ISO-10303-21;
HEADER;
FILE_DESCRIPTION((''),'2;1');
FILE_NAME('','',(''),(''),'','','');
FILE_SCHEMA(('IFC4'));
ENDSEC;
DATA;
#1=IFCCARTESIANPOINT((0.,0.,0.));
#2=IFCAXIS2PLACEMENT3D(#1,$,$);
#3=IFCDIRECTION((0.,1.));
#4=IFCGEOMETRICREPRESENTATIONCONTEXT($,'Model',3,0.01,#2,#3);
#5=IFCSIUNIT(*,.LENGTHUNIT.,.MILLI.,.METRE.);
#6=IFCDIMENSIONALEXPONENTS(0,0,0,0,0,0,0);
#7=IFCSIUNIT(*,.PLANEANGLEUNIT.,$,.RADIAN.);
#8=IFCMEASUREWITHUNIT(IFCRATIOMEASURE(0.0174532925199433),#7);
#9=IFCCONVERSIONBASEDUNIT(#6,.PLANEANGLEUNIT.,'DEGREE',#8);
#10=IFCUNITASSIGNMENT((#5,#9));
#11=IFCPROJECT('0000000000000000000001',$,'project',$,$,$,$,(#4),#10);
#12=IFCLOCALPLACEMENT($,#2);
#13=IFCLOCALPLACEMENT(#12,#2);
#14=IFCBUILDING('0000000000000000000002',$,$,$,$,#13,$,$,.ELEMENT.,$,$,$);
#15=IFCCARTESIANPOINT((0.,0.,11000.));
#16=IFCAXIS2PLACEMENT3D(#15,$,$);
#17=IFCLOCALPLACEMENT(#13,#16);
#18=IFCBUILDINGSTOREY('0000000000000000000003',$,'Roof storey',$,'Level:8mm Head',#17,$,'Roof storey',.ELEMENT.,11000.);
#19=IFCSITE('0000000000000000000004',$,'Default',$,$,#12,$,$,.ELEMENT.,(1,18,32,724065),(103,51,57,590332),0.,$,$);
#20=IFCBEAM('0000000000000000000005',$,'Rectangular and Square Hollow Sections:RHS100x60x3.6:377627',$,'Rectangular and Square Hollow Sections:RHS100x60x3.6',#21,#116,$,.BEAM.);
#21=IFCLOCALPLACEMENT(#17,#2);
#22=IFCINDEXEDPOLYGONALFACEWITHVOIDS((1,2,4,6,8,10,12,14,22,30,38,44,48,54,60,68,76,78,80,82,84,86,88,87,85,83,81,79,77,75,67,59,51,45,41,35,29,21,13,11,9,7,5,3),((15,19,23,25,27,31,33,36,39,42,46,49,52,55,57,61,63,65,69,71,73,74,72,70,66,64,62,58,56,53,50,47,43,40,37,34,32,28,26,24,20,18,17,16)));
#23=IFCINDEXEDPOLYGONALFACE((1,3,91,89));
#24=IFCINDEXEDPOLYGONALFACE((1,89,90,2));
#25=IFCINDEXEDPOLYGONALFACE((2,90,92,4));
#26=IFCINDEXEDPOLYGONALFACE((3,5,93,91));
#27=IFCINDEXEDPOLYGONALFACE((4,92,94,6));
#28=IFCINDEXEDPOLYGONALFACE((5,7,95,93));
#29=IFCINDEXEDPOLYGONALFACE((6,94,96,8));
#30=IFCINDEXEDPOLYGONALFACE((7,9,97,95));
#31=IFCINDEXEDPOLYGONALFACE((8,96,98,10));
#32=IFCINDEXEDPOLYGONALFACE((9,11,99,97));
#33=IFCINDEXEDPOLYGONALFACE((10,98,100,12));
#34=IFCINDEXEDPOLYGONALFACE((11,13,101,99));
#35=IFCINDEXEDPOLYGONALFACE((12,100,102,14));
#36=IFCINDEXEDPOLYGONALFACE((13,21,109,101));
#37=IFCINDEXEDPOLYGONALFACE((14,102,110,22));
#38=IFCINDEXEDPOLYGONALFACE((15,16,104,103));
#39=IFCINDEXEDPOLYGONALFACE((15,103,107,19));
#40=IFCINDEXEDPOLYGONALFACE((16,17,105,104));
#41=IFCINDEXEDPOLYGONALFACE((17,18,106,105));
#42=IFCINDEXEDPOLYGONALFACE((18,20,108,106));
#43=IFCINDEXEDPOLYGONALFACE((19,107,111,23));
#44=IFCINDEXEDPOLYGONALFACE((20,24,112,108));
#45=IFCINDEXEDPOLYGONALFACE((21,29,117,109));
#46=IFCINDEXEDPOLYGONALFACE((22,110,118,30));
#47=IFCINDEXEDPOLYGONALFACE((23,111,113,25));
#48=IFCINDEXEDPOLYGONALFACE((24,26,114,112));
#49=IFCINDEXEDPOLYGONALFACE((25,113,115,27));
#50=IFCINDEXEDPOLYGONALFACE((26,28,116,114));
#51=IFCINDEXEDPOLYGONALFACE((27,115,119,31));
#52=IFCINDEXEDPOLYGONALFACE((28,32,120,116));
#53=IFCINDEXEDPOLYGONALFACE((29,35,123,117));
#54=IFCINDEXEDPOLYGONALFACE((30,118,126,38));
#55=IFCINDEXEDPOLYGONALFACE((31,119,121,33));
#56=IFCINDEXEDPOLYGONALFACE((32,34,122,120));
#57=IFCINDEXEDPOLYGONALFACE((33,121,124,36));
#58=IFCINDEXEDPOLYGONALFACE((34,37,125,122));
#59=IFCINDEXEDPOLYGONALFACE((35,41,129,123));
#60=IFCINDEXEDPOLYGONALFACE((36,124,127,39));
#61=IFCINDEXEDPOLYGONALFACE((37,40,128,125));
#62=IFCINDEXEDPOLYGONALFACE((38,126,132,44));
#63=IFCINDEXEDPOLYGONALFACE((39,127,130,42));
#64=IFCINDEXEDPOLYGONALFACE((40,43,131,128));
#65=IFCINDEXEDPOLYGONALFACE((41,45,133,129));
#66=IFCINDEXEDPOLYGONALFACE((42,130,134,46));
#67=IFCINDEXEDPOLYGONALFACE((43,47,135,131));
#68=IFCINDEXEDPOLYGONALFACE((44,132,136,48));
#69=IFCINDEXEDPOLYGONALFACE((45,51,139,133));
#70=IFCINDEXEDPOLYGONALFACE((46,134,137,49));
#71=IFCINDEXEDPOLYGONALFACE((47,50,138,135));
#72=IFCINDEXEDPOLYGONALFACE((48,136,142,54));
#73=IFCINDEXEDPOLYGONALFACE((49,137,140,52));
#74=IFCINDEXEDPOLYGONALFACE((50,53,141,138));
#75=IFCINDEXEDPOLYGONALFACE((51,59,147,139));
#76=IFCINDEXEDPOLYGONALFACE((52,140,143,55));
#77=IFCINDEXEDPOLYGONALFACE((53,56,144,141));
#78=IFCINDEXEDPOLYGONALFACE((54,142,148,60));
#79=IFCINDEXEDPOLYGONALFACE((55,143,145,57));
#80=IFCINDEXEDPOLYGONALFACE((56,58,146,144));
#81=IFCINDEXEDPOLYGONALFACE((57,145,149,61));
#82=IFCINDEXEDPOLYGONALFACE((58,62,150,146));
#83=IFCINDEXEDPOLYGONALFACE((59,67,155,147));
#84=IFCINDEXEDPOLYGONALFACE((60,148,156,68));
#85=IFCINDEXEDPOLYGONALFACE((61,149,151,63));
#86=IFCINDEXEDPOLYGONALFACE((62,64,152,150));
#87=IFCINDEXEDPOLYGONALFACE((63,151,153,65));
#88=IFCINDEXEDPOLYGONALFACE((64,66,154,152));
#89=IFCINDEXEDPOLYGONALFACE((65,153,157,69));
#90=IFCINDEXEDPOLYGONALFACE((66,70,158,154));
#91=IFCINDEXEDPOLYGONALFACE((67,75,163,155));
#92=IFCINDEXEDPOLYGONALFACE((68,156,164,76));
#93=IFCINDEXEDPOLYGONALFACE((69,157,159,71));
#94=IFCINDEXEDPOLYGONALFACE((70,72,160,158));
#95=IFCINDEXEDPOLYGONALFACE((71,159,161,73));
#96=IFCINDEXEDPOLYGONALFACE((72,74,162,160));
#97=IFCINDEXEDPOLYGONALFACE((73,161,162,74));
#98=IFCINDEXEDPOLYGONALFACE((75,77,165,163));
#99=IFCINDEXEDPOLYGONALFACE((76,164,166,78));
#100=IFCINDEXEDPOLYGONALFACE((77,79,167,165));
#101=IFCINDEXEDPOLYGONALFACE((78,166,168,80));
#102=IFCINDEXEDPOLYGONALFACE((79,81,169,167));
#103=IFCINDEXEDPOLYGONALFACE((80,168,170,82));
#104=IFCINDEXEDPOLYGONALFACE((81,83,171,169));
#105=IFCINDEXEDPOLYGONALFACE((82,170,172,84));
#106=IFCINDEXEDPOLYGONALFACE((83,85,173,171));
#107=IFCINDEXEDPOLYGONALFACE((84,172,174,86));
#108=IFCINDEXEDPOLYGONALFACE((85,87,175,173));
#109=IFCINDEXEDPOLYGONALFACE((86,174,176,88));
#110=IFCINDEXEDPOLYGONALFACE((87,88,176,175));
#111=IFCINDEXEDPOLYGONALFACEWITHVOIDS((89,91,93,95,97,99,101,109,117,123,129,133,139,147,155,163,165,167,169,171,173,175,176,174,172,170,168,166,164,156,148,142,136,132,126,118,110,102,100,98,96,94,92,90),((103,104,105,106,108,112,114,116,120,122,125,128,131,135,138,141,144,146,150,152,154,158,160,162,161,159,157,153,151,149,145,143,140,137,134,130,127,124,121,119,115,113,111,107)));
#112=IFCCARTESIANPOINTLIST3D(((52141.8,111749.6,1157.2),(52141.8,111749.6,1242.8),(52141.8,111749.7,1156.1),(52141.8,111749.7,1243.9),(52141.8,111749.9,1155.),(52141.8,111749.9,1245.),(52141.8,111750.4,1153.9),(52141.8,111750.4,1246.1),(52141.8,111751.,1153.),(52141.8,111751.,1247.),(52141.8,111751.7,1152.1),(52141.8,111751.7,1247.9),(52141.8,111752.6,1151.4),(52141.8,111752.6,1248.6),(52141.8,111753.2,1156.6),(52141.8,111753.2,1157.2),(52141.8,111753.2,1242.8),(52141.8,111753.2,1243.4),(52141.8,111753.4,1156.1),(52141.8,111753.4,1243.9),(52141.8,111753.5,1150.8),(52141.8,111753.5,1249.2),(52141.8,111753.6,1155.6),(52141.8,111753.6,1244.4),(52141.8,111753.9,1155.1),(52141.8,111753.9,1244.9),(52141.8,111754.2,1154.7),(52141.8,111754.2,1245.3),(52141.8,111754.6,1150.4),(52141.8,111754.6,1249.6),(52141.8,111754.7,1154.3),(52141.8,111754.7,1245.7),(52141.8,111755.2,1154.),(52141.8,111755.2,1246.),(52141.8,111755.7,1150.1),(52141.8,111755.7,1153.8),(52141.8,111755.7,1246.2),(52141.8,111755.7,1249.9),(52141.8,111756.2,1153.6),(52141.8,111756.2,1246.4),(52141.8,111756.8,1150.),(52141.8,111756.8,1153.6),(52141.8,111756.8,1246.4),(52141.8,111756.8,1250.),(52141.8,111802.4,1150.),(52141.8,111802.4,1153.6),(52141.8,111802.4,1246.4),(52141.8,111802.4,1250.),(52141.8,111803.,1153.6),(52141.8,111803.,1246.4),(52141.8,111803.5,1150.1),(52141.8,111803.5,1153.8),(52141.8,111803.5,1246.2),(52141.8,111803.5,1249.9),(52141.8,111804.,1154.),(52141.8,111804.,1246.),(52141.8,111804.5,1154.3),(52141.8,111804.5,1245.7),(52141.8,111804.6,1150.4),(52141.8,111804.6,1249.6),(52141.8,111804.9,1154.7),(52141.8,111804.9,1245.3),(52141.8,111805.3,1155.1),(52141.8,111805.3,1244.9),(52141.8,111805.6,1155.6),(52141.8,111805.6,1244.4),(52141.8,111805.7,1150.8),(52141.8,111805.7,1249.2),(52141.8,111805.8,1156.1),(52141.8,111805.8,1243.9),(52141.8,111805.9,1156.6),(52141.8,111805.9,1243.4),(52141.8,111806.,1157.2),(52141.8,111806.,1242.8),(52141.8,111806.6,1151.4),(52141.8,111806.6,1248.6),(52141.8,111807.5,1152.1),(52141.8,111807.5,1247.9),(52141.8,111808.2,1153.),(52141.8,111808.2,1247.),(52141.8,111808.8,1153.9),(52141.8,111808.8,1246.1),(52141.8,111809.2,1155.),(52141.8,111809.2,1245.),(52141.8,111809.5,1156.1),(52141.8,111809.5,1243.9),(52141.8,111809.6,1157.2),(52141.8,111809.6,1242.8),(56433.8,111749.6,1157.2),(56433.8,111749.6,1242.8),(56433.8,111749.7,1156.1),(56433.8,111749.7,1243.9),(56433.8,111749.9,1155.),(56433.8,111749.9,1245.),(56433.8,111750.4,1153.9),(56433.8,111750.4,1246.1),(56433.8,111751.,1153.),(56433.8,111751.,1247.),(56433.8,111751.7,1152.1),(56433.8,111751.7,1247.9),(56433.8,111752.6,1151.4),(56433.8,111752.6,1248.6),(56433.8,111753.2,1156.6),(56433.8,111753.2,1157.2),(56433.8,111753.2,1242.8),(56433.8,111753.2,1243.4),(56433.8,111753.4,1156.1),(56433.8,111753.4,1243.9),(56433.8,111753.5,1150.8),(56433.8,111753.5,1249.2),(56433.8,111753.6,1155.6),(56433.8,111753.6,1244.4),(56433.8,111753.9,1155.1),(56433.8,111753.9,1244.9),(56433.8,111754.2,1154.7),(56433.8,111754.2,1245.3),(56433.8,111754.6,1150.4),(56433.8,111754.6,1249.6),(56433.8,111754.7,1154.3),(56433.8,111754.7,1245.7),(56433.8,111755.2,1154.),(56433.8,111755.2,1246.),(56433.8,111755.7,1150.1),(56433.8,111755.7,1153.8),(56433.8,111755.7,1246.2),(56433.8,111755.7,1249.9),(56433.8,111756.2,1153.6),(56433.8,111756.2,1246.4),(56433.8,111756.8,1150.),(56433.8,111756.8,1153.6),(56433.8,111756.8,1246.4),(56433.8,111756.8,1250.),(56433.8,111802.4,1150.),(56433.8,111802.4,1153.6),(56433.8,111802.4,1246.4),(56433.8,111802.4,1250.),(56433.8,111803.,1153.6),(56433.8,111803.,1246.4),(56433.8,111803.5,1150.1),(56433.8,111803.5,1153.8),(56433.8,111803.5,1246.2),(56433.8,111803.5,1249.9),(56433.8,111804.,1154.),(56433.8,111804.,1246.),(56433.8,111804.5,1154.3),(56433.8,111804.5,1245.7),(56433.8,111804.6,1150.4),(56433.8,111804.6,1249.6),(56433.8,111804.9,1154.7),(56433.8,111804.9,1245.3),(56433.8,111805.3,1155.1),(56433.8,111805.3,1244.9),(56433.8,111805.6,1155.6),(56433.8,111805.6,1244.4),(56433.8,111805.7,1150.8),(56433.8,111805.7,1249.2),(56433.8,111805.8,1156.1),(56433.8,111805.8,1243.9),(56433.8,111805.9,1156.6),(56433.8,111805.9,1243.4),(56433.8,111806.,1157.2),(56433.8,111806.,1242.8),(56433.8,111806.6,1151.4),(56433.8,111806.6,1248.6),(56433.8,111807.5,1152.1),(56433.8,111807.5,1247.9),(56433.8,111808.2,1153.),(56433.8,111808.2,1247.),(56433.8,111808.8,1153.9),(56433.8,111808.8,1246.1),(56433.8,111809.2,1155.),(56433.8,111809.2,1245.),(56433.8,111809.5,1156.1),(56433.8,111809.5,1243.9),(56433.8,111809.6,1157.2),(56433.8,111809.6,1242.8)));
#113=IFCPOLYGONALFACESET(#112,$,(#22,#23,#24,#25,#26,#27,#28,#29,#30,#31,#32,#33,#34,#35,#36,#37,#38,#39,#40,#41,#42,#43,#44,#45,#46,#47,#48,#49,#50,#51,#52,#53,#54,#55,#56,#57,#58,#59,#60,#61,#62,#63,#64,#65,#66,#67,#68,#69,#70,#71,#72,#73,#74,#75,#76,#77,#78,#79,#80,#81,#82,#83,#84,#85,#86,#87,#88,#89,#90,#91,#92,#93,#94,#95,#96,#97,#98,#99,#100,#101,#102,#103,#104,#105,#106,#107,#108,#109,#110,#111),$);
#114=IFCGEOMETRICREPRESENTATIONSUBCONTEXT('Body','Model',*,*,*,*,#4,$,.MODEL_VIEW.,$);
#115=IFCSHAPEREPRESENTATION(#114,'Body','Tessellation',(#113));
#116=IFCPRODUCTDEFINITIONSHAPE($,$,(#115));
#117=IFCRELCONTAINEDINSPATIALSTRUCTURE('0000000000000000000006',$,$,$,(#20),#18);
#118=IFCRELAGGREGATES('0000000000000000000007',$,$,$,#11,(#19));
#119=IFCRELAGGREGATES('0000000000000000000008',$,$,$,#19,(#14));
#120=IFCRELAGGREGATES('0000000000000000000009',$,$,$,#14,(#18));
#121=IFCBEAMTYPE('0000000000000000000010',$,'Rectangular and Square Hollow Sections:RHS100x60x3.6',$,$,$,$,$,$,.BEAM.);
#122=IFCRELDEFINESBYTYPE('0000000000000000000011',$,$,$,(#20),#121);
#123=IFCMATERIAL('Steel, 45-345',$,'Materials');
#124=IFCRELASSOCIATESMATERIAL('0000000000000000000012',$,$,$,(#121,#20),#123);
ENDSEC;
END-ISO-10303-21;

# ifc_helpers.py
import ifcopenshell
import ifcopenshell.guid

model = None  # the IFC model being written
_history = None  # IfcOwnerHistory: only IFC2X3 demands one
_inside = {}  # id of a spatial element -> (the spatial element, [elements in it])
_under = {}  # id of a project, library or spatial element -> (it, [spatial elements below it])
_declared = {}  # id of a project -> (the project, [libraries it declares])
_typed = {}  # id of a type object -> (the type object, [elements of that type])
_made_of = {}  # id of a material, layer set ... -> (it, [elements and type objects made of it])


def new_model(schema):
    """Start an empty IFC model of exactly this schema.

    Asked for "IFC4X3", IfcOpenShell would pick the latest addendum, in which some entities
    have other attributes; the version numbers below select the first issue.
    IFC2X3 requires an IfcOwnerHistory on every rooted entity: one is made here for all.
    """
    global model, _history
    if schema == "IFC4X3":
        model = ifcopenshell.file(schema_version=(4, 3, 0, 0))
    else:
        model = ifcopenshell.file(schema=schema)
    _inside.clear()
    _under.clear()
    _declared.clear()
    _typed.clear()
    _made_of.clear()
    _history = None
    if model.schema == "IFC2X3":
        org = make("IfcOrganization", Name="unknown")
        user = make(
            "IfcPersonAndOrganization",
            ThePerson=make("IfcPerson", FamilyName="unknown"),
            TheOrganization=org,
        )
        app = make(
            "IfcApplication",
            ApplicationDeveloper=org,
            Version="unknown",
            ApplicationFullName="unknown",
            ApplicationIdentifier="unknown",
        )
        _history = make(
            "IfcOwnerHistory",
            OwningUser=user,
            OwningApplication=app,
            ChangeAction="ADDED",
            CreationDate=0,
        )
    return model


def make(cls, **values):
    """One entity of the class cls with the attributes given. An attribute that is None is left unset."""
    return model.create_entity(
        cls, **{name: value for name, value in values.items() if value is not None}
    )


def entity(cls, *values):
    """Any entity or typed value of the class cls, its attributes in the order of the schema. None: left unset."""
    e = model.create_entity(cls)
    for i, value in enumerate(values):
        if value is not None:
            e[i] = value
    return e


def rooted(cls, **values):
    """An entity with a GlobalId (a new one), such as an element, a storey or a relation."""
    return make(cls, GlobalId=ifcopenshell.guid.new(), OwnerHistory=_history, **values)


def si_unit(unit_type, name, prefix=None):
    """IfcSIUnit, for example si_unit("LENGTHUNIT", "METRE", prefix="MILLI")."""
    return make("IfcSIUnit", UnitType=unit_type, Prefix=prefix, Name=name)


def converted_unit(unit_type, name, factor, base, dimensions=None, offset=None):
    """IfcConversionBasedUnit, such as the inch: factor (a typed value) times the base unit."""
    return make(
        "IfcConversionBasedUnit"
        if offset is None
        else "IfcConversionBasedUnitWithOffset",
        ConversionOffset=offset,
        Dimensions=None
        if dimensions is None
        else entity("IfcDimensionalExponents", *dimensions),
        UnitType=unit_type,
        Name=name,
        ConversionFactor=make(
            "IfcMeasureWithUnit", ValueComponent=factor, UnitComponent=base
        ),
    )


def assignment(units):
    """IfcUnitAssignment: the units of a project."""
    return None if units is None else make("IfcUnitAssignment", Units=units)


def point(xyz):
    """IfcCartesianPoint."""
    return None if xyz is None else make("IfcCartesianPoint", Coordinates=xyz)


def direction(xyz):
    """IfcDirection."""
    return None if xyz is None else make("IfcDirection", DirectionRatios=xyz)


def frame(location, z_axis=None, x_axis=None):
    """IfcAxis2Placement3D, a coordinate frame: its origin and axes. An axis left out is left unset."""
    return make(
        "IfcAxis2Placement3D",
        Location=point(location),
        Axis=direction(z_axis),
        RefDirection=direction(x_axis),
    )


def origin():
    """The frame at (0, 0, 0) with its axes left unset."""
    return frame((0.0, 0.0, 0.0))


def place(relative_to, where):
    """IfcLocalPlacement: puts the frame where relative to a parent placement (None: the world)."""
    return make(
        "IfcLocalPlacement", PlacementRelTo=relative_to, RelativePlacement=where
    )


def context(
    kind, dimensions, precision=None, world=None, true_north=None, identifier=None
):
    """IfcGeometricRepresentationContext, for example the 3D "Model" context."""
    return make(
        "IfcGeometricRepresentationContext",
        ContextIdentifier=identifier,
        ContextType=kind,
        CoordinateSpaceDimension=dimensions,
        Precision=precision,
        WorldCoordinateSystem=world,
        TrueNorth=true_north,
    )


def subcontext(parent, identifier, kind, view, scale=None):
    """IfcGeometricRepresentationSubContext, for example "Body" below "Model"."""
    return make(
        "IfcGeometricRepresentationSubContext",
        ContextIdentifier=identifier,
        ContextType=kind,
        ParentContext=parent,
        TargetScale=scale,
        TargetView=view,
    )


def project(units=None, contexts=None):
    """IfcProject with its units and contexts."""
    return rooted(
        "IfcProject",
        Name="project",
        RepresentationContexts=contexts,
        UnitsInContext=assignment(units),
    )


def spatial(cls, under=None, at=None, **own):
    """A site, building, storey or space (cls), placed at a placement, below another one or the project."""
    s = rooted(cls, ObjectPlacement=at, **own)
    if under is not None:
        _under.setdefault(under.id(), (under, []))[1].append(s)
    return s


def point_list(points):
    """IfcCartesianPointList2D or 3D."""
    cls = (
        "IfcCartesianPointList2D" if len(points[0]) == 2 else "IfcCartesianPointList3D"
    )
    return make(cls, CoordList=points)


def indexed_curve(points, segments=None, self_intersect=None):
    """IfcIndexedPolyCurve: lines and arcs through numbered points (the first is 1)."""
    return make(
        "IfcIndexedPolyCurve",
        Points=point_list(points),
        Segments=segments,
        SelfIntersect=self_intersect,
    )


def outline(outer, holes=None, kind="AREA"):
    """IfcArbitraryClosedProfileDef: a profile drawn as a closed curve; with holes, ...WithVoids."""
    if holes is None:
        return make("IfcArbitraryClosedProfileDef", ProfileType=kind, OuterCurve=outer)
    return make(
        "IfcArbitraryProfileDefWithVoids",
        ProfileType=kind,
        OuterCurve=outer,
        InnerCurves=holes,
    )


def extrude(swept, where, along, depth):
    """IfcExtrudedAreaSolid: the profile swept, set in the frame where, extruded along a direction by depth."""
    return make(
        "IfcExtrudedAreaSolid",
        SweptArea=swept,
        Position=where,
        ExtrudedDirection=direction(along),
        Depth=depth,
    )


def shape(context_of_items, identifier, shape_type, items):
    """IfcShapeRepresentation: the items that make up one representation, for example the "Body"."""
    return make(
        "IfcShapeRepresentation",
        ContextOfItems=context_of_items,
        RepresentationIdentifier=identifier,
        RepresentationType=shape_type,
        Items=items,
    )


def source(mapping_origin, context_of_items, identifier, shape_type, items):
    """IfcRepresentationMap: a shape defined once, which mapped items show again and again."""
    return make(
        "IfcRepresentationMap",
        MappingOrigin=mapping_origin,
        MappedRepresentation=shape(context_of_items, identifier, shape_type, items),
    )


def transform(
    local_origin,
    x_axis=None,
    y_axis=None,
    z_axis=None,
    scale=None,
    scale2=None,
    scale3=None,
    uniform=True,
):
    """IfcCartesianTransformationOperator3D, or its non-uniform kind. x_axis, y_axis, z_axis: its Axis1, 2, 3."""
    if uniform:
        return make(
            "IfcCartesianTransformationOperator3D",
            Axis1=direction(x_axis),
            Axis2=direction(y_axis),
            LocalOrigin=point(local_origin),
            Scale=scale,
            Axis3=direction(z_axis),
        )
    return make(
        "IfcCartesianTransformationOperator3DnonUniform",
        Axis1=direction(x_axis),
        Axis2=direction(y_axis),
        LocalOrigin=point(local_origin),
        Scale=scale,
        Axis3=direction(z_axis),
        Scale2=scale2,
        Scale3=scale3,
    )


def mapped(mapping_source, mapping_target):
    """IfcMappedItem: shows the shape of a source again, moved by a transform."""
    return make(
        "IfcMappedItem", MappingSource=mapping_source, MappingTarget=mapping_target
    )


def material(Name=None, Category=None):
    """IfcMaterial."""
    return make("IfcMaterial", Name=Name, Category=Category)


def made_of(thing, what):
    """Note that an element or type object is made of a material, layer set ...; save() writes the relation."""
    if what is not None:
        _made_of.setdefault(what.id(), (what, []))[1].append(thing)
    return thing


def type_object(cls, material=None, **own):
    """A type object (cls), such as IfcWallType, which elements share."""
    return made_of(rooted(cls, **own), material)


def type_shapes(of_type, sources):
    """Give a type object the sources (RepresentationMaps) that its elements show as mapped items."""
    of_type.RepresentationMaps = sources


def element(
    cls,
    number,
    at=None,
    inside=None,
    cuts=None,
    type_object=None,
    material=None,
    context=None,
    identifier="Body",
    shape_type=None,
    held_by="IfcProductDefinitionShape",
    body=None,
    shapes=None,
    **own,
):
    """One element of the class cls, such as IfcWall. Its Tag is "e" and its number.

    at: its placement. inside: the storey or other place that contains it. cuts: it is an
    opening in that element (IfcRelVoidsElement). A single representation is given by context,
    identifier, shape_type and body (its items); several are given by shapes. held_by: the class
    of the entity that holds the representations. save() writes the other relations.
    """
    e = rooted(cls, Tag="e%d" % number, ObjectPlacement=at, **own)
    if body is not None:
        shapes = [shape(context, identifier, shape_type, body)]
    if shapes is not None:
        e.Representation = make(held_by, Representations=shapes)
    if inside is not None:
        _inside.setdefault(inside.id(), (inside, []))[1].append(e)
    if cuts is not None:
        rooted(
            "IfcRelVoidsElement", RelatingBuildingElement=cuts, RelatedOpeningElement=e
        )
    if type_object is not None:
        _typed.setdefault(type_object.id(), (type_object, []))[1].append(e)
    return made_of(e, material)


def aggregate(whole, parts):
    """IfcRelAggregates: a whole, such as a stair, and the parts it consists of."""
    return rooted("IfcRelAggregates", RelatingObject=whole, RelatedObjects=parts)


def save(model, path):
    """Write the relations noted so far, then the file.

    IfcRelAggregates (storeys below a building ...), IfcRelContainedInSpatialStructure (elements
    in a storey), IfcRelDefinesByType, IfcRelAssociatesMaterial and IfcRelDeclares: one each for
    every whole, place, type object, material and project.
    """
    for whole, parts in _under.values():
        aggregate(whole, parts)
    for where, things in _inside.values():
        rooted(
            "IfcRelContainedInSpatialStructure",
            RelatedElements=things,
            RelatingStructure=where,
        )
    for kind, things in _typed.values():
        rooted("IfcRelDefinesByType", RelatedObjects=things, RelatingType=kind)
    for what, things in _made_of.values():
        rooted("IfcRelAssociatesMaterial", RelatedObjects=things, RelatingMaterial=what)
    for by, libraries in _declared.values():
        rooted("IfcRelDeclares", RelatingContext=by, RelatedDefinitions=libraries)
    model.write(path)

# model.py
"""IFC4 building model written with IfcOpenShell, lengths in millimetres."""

from ifc_helpers import new_model, entity, si_unit, converted_unit, direction, frame, origin, place, context, subcontext, project, spatial, indexed_curve, outline, extrude, source, transform, mapped, material, type_object, type_shapes, element, save


model = new_model("IFC4")

# Units and contexts
model_context = context("Model", 3, precision=0.01, world=origin(), true_north=direction((0.0, 1.0)))
body_context = subcontext(model_context, "Body", "Model", "MODEL_VIEW")
ifc_project = project(units=[si_unit("LENGTHUNIT", "METRE", prefix="MILLI"), converted_unit("PLANEANGLEUNIT", "DEGREE", entity("IfcRatioMeasure", 0.0174532925199433), si_unit("PLANEANGLEUNIT", "RADIAN"), dimensions=[0, 0, 0, 0, 0, 0, 0])], contexts=[model_context])

# Site, building, storey
site_placement = place(None, origin())
site = spatial("IfcSite", under=ifc_project, at=site_placement, Name="Default", CompositionType="ELEMENT", RefLatitude=(1, 18, 32, 724065), RefLongitude=(103, 51, 57, 590332), RefElevation=0.0)
building_placement = place(site_placement, origin())
building = spatial("IfcBuilding", under=site, at=building_placement, CompositionType="ELEMENT")
storey_placement = place(building_placement, frame((0.0, 0.0, 11000.0)))
storey = spatial("IfcBuildingStorey", under=building, at=storey_placement, Name="Roof storey", ObjectType="Level:8mm Head", LongName="Roof storey", CompositionType="ELEMENT", Elevation=11000.0)

# Shared definitions
ifc_material = material(Name="Steel, 45-345", Category="Materials")

# Beam
beam_type_1 = type_object("IfcBeamType", Name="Rectangular and Square Hollow Sections:RHS100x60x3.6", PredefinedType="BEAM", material=ifc_material)
shared_shape_1 = source(origin(), body_context, "Body", "SweptSolid", [
    extrude(outline(indexed_curve([(-30.0, -42.8), (-29.9, -43.9), (-29.6, -45.0), (-29.2, -46.1), (-28.6, -47.0), (-27.9, -47.9), (-27.0, -48.6), (-26.1, -49.2), (-25.0, -49.6), (-23.9, -49.9), (-22.8, -50.0), (22.8, -50.0), (23.9, -49.9), (25.0, -49.6), (26.1, -49.2), (27.0, -48.6), (27.9, -47.9), (28.6, -47.0), (29.2, -46.1), (29.6, -45.0), (29.9, -43.9), (30.0, -42.8), (30.0, 42.8), (29.9, 43.9), (29.6, 45.0), (29.2, 46.1), (28.6, 47.0), (27.9, 47.9), (27.0, 48.6), (26.1, 49.2), (25.0, 49.6), (23.9, 49.9), (22.8, 50.0), (-22.8, 50.0), (-23.9, 49.9), (-25.0, 49.6), (-26.1, 49.2), (-27.0, 48.6), (-27.9, 47.9), (-28.6, 47.0), (-29.2, 46.1), (-29.6, 45.0), (-29.9, 43.9), (-30.0, 42.8), (-30.0, -42.8)], self_intersect=False), holes=[indexed_curve([(22.8, -46.4), (-22.8, -46.4), (-23.4, -46.4), (-23.9, -46.2), (-24.4, -46.0), (-24.9, -45.7), (-25.3, -45.3), (-25.7, -44.9), (-26.0, -44.4), (-26.2, -43.9), (-26.4, -43.4), (-26.4, -42.8), (-26.4, 42.8), (-26.4, 43.4), (-26.2, 43.9), (-26.0, 44.4), (-25.7, 44.9), (-25.3, 45.3), (-24.9, 45.7), (-24.4, 46.0), (-23.9, 46.2), (-23.4, 46.4), (-22.8, 46.4), (22.8, 46.4), (23.4, 46.4), (23.9, 46.2), (24.4, 46.0), (24.9, 45.7), (25.3, 45.3), (25.7, 44.9), (26.0, 44.4), (26.2, 43.9), (26.4, 43.4), (26.4, 42.8), (26.4, -42.8), (26.4, -43.4), (26.2, -43.9), (26.0, -44.4), (25.7, -44.9), (25.3, -45.3), (24.9, -45.7), (24.4, -46.0), (23.9, -46.2), (23.4, -46.4), (22.8, -46.4)], self_intersect=False)]), frame((-2152.5, 0.0, 0.0), z_axis=(1.0, 0.0, 0.0), x_axis=(0.0, -1.0, 0.0)), (0.0, 0.0, 1.0), 4292.0),
])
type_shapes(beam_type_1, [shared_shape_1])
for number, where, name in (
    (1, (54294.3, 111779.6, 1200.0), "Rectangular and Square Hollow Sections:RHS100x60x3.6:377627"),
):
    element("IfcBeam", number, at=place(storey_placement, frame(where)), inside=storey, type_object=beam_type_1, material=ifc_material, Name=name, ObjectType="Rectangular and Square Hollow Sections:RHS100x60x3.6", PredefinedType="BEAM", context=body_context, shape_type="MappedRepresentation", body=[
        mapped(shared_shape_1, transform((0.0, 0.0, 0.0), scale=1.0)),
    ])

save(model, "model.ifc")
